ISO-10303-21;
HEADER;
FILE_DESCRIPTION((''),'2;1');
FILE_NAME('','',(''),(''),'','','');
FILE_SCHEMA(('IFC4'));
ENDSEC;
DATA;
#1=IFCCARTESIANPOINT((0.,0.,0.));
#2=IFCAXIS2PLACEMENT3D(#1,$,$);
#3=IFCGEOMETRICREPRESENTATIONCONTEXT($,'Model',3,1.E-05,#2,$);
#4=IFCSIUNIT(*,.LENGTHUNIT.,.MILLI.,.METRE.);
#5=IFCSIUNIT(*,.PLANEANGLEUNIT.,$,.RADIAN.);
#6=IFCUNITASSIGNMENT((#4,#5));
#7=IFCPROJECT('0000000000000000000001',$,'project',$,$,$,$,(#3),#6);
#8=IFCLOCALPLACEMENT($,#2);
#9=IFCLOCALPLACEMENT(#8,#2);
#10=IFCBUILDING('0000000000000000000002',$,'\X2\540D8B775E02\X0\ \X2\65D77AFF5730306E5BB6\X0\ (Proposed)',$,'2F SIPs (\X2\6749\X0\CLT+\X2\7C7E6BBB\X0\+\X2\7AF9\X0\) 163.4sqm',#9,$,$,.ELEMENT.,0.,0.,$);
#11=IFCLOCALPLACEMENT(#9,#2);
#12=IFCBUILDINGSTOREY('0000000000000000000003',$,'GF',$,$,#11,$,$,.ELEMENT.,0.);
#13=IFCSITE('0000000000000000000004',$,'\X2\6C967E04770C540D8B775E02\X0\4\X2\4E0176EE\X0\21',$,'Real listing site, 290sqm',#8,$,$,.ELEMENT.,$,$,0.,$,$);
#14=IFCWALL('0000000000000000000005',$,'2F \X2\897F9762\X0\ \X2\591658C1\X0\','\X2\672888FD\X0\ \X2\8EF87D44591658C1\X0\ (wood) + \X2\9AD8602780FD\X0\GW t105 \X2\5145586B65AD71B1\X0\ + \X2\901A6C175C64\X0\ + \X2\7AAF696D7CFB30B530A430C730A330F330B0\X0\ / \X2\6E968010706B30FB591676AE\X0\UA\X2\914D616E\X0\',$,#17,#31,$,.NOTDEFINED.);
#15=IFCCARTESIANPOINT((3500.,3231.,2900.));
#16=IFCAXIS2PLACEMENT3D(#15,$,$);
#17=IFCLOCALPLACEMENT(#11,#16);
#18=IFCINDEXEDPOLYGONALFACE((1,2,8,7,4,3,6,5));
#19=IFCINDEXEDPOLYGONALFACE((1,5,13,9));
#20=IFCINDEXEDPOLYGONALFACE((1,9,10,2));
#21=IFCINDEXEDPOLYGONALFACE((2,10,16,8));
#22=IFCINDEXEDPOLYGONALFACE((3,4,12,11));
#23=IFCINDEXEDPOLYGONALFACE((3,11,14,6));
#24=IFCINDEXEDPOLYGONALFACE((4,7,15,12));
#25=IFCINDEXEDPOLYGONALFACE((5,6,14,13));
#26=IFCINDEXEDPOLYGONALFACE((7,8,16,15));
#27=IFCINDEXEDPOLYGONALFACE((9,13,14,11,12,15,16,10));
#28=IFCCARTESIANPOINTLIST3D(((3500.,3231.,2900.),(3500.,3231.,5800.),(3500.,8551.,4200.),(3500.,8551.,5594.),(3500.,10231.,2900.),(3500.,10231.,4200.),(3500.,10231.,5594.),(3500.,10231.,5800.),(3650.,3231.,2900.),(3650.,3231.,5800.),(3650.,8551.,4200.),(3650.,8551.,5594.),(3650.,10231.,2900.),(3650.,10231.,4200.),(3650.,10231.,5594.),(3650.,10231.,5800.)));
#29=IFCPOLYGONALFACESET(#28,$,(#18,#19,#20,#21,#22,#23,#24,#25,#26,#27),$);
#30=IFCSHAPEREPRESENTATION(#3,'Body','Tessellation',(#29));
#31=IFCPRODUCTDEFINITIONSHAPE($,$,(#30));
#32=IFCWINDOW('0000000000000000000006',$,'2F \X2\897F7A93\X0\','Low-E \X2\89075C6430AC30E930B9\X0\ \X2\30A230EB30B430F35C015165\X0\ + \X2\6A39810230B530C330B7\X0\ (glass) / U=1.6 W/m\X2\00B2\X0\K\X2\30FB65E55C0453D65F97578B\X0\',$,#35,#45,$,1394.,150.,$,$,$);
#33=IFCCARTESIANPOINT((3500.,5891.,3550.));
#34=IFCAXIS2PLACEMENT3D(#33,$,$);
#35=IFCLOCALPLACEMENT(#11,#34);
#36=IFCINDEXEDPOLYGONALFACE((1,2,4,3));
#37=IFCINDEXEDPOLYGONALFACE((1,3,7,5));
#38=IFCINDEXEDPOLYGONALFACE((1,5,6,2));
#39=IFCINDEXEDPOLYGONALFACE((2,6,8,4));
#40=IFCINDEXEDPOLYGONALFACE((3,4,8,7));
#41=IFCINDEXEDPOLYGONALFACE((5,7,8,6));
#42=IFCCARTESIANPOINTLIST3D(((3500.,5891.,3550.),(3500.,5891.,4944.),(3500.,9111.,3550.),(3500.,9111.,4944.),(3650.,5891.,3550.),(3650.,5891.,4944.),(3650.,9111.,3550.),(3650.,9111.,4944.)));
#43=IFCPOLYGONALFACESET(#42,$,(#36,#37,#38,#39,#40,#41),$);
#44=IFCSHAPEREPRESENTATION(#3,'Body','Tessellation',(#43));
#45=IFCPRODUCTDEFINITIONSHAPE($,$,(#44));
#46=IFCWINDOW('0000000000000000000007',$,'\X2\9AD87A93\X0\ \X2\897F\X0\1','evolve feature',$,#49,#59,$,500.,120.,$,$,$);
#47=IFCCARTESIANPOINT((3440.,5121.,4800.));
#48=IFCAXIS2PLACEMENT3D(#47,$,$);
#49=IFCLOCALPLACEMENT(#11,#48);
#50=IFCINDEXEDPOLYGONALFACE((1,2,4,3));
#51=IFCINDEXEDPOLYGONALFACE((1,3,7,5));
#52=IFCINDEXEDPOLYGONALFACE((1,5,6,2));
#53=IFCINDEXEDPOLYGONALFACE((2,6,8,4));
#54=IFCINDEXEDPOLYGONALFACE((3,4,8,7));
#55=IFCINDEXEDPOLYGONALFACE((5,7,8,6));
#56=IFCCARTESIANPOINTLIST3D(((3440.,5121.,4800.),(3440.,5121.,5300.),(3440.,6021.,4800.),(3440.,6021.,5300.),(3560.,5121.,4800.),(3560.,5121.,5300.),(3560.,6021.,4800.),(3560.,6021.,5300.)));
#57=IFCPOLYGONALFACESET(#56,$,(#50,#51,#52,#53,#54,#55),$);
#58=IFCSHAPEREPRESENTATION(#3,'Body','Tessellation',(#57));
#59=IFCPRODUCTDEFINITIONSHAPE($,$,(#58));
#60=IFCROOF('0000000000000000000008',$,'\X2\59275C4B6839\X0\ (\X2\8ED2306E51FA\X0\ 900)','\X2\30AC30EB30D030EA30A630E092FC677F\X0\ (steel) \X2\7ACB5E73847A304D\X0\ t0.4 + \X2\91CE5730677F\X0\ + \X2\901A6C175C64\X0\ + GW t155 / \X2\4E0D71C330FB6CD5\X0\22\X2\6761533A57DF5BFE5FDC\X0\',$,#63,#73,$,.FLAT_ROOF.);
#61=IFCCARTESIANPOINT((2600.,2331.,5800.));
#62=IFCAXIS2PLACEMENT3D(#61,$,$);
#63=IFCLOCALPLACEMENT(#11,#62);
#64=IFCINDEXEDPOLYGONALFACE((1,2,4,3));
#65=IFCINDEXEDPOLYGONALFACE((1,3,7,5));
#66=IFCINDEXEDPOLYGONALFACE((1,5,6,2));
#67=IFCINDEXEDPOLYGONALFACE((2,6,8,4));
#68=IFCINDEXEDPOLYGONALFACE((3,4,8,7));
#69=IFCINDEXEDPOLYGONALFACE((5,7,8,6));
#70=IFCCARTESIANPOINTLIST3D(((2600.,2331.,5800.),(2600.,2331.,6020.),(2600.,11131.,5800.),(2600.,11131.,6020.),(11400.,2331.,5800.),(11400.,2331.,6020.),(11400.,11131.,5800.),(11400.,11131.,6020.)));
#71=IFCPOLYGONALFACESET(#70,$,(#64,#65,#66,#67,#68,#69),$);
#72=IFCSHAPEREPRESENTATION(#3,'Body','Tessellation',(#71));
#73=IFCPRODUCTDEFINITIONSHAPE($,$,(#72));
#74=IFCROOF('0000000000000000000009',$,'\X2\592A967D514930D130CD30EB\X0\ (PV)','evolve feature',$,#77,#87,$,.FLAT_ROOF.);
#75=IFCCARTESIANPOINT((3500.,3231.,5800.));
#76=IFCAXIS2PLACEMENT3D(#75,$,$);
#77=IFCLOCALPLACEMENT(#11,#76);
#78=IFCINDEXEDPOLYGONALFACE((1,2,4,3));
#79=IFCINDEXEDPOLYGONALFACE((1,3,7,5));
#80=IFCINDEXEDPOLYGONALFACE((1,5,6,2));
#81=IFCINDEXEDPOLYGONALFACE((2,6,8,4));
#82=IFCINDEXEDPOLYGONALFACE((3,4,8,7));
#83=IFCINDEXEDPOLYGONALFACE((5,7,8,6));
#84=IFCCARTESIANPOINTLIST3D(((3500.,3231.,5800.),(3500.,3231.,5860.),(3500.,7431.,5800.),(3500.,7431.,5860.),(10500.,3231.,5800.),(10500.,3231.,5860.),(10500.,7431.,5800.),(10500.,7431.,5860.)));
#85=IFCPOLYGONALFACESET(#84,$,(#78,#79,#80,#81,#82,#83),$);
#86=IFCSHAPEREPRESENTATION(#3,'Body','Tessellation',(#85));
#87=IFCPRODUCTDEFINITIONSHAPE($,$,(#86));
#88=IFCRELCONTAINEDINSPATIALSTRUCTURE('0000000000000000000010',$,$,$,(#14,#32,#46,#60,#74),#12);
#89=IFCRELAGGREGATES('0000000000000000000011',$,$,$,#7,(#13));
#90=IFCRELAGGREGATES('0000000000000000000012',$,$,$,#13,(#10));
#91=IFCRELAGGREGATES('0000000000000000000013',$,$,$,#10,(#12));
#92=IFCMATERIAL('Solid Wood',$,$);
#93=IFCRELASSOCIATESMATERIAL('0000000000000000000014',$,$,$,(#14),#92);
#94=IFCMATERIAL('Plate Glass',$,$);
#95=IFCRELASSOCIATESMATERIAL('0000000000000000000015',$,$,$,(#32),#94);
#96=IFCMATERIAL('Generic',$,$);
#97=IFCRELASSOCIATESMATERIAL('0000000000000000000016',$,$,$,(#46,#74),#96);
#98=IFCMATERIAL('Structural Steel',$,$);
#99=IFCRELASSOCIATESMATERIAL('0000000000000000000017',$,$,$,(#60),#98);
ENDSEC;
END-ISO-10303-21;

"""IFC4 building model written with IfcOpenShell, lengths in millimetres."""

from ifc_helpers import new_model, si_unit, frame, frame_2d, origin, place, context, project, spatial, rectangle, extrude, material, element, fill, save


model = new_model("IFC4")

# Units and contexts
model_context = context("Model", 3, precision=1e-05, world=origin())
ifc_project = project(units=[si_unit("LENGTHUNIT", "METRE", prefix="MILLI"), si_unit("PLANEANGLEUNIT", "RADIAN")], contexts=[model_context])

# Site, building, storey
site_placement = place(None, origin())
site = spatial("IfcSite", under=ifc_project, at=site_placement, Name="沖縄県名護市4丁目21", ObjectType="Real listing site, 290sqm", CompositionType="ELEMENT", RefElevation=0.0)
building_placement = place(site_placement, origin())
building = spatial("IfcBuilding", under=site, at=building_placement, Name="名護市 旗竿地の家 (Proposed)", ObjectType="2F SIPs (杉CLT+籾殻+竹) 163.4sqm", CompositionType="ELEMENT", ElevationOfRefHeight=0.0, ElevationOfTerrain=0.0)
storey_placement = place(building_placement, origin())
storey = spatial("IfcBuildingStorey", under=building, at=storey_placement, Name="GF", CompositionType="ELEMENT", Elevation=0.0)

# Shared definitions
ifc_material_1 = material(Name="Solid Wood")
ifc_material_2 = material(Name="Generic")

# Shared definitions
ifc_material_3 = material(Name="Plate Glass")

# Wall, openings, windows
wall_1_placement = place(storey_placement, frame((3500.0, 3231.0, 2900.0)))
wall_1 = element("IfcWall", 1, at=wall_1_placement, inside=storey, material=ifc_material_1, Name="2F 西面 外壁", Description="木製 軸組外壁 (wood) + 高性能GW t105 充填断熱 + 通気層 + 窯業系サイディング / 準耐火・外皮UA配慮", PredefinedType="NOTDEFINED", context=model_context, shape_type="SweptSolid", body=[
    extrude(rectangle(XDim=150.0, YDim=7000.0, at=frame_2d((75.0, 3500.0))), frame((3500.0, 3231.0, 2900.0)), (0.0, 0.0, 1.0), 2900.0),
])
opening_1_placement = place(storey_placement, frame((3500.0, 5891.0, 3550.0)))
opening_1 = element("IfcOpeningElement", 2, at=opening_1_placement, cuts=wall_1, PredefinedType="NOTDEFINED", context=model_context, shape_type="SweptSolid", body=[
    extrude(rectangle(XDim=150.0, YDim=3220.0, at=frame_2d((75.0, 1610.0))), frame((3500.0, 5891.0, 3550.0)), (0.0, 0.0, 1.0), 1394.0),
])
opening_2_placement = place(storey_placement, frame((3440.0, 5121.0, 4800.0)))
opening_2 = element("IfcOpeningElement", 3, at=opening_2_placement, cuts=wall_1, PredefinedType="NOTDEFINED", context=model_context, shape_type="SweptSolid", body=[
    extrude(rectangle(XDim=120.0, YDim=900.0, at=frame_2d((60.0, 450.0))), frame((3440.0, 5121.0, 4800.0)), (0.0, 0.0, 1.0), 500.0),
])
window_1_placement = place(storey_placement, frame((3500.0, 5891.0, 3550.0)))
window_1 = element("IfcWindow", 4, at=window_1_placement, inside=storey, material=ifc_material_3, Name="2F 西窓", Description="Low-E 複層ガラス アルゴン封入 + 樹脂サッシ (glass) / U=1.6 W/m²K・日射取得型", OverallHeight=1394.0, OverallWidth=150.0, context=model_context, shape_type="SweptSolid", body=[
    extrude(rectangle(XDim=150.0, YDim=3220.0, at=frame_2d((75.0, 1610.0))), frame((3500.0, 5891.0, 3550.0)), (0.0, 0.0, 1.0), 1394.0),
])
fill(opening_1, window_1)
window_2_placement = place(storey_placement, frame((3440.0, 5121.0, 4800.0)))
window_2 = element("IfcWindow", 5, at=window_2_placement, inside=storey, material=ifc_material_2, Name="高窓 西1", Description="evolve feature", OverallHeight=500.0, OverallWidth=120.0, context=model_context, shape_type="SweptSolid", body=[
    extrude(rectangle(XDim=120.0, YDim=900.0, at=frame_2d((60.0, 450.0))), frame((3440.0, 5121.0, 4800.0)), (0.0, 0.0, 1.0), 500.0),
])
fill(opening_2, window_2)

# Roofs
ifc_material_4 = material(Name="Structural Steel")
roof_1_placement = place(storey_placement, frame((2600.0, 2331.0, 5800.0)))
element("IfcRoof", 6, at=roof_1_placement, inside=storey, material=ifc_material_4, Name="大屋根 (軒の出 900)", Description="ガルバリウム鋼板 (steel) 立平葺き t0.4 + 野地板 + 通気層 + GW t155 / 不燃・法22条区域対応", PredefinedType="FLAT_ROOF", context=model_context, shape_type="SweptSolid", body=[
    extrude(rectangle(XDim=8800.0, YDim=8800.0, at=frame_2d((4400.0, 4400.0))), frame((2600.0, 2331.0, 5800.0)), (0.0, 0.0, 1.0), 220.0),
])
roof_2_placement = place(storey_placement, frame((3500.0, 3231.0, 5800.0)))
element("IfcRoof", 7, at=roof_2_placement, inside=storey, material=ifc_material_2, Name="太陽光パネル (PV)", Description="evolve feature", PredefinedType="FLAT_ROOF", context=model_context, shape_type="SweptSolid", body=[
    extrude(rectangle(XDim=7000.0, YDim=4200.0, at=frame_2d((3500.0, 2100.0))), frame((3500.0, 3231.0, 5800.0)), (0.0, 0.0, 1.0), 60.0),
])

save(model, "model.ifc")
